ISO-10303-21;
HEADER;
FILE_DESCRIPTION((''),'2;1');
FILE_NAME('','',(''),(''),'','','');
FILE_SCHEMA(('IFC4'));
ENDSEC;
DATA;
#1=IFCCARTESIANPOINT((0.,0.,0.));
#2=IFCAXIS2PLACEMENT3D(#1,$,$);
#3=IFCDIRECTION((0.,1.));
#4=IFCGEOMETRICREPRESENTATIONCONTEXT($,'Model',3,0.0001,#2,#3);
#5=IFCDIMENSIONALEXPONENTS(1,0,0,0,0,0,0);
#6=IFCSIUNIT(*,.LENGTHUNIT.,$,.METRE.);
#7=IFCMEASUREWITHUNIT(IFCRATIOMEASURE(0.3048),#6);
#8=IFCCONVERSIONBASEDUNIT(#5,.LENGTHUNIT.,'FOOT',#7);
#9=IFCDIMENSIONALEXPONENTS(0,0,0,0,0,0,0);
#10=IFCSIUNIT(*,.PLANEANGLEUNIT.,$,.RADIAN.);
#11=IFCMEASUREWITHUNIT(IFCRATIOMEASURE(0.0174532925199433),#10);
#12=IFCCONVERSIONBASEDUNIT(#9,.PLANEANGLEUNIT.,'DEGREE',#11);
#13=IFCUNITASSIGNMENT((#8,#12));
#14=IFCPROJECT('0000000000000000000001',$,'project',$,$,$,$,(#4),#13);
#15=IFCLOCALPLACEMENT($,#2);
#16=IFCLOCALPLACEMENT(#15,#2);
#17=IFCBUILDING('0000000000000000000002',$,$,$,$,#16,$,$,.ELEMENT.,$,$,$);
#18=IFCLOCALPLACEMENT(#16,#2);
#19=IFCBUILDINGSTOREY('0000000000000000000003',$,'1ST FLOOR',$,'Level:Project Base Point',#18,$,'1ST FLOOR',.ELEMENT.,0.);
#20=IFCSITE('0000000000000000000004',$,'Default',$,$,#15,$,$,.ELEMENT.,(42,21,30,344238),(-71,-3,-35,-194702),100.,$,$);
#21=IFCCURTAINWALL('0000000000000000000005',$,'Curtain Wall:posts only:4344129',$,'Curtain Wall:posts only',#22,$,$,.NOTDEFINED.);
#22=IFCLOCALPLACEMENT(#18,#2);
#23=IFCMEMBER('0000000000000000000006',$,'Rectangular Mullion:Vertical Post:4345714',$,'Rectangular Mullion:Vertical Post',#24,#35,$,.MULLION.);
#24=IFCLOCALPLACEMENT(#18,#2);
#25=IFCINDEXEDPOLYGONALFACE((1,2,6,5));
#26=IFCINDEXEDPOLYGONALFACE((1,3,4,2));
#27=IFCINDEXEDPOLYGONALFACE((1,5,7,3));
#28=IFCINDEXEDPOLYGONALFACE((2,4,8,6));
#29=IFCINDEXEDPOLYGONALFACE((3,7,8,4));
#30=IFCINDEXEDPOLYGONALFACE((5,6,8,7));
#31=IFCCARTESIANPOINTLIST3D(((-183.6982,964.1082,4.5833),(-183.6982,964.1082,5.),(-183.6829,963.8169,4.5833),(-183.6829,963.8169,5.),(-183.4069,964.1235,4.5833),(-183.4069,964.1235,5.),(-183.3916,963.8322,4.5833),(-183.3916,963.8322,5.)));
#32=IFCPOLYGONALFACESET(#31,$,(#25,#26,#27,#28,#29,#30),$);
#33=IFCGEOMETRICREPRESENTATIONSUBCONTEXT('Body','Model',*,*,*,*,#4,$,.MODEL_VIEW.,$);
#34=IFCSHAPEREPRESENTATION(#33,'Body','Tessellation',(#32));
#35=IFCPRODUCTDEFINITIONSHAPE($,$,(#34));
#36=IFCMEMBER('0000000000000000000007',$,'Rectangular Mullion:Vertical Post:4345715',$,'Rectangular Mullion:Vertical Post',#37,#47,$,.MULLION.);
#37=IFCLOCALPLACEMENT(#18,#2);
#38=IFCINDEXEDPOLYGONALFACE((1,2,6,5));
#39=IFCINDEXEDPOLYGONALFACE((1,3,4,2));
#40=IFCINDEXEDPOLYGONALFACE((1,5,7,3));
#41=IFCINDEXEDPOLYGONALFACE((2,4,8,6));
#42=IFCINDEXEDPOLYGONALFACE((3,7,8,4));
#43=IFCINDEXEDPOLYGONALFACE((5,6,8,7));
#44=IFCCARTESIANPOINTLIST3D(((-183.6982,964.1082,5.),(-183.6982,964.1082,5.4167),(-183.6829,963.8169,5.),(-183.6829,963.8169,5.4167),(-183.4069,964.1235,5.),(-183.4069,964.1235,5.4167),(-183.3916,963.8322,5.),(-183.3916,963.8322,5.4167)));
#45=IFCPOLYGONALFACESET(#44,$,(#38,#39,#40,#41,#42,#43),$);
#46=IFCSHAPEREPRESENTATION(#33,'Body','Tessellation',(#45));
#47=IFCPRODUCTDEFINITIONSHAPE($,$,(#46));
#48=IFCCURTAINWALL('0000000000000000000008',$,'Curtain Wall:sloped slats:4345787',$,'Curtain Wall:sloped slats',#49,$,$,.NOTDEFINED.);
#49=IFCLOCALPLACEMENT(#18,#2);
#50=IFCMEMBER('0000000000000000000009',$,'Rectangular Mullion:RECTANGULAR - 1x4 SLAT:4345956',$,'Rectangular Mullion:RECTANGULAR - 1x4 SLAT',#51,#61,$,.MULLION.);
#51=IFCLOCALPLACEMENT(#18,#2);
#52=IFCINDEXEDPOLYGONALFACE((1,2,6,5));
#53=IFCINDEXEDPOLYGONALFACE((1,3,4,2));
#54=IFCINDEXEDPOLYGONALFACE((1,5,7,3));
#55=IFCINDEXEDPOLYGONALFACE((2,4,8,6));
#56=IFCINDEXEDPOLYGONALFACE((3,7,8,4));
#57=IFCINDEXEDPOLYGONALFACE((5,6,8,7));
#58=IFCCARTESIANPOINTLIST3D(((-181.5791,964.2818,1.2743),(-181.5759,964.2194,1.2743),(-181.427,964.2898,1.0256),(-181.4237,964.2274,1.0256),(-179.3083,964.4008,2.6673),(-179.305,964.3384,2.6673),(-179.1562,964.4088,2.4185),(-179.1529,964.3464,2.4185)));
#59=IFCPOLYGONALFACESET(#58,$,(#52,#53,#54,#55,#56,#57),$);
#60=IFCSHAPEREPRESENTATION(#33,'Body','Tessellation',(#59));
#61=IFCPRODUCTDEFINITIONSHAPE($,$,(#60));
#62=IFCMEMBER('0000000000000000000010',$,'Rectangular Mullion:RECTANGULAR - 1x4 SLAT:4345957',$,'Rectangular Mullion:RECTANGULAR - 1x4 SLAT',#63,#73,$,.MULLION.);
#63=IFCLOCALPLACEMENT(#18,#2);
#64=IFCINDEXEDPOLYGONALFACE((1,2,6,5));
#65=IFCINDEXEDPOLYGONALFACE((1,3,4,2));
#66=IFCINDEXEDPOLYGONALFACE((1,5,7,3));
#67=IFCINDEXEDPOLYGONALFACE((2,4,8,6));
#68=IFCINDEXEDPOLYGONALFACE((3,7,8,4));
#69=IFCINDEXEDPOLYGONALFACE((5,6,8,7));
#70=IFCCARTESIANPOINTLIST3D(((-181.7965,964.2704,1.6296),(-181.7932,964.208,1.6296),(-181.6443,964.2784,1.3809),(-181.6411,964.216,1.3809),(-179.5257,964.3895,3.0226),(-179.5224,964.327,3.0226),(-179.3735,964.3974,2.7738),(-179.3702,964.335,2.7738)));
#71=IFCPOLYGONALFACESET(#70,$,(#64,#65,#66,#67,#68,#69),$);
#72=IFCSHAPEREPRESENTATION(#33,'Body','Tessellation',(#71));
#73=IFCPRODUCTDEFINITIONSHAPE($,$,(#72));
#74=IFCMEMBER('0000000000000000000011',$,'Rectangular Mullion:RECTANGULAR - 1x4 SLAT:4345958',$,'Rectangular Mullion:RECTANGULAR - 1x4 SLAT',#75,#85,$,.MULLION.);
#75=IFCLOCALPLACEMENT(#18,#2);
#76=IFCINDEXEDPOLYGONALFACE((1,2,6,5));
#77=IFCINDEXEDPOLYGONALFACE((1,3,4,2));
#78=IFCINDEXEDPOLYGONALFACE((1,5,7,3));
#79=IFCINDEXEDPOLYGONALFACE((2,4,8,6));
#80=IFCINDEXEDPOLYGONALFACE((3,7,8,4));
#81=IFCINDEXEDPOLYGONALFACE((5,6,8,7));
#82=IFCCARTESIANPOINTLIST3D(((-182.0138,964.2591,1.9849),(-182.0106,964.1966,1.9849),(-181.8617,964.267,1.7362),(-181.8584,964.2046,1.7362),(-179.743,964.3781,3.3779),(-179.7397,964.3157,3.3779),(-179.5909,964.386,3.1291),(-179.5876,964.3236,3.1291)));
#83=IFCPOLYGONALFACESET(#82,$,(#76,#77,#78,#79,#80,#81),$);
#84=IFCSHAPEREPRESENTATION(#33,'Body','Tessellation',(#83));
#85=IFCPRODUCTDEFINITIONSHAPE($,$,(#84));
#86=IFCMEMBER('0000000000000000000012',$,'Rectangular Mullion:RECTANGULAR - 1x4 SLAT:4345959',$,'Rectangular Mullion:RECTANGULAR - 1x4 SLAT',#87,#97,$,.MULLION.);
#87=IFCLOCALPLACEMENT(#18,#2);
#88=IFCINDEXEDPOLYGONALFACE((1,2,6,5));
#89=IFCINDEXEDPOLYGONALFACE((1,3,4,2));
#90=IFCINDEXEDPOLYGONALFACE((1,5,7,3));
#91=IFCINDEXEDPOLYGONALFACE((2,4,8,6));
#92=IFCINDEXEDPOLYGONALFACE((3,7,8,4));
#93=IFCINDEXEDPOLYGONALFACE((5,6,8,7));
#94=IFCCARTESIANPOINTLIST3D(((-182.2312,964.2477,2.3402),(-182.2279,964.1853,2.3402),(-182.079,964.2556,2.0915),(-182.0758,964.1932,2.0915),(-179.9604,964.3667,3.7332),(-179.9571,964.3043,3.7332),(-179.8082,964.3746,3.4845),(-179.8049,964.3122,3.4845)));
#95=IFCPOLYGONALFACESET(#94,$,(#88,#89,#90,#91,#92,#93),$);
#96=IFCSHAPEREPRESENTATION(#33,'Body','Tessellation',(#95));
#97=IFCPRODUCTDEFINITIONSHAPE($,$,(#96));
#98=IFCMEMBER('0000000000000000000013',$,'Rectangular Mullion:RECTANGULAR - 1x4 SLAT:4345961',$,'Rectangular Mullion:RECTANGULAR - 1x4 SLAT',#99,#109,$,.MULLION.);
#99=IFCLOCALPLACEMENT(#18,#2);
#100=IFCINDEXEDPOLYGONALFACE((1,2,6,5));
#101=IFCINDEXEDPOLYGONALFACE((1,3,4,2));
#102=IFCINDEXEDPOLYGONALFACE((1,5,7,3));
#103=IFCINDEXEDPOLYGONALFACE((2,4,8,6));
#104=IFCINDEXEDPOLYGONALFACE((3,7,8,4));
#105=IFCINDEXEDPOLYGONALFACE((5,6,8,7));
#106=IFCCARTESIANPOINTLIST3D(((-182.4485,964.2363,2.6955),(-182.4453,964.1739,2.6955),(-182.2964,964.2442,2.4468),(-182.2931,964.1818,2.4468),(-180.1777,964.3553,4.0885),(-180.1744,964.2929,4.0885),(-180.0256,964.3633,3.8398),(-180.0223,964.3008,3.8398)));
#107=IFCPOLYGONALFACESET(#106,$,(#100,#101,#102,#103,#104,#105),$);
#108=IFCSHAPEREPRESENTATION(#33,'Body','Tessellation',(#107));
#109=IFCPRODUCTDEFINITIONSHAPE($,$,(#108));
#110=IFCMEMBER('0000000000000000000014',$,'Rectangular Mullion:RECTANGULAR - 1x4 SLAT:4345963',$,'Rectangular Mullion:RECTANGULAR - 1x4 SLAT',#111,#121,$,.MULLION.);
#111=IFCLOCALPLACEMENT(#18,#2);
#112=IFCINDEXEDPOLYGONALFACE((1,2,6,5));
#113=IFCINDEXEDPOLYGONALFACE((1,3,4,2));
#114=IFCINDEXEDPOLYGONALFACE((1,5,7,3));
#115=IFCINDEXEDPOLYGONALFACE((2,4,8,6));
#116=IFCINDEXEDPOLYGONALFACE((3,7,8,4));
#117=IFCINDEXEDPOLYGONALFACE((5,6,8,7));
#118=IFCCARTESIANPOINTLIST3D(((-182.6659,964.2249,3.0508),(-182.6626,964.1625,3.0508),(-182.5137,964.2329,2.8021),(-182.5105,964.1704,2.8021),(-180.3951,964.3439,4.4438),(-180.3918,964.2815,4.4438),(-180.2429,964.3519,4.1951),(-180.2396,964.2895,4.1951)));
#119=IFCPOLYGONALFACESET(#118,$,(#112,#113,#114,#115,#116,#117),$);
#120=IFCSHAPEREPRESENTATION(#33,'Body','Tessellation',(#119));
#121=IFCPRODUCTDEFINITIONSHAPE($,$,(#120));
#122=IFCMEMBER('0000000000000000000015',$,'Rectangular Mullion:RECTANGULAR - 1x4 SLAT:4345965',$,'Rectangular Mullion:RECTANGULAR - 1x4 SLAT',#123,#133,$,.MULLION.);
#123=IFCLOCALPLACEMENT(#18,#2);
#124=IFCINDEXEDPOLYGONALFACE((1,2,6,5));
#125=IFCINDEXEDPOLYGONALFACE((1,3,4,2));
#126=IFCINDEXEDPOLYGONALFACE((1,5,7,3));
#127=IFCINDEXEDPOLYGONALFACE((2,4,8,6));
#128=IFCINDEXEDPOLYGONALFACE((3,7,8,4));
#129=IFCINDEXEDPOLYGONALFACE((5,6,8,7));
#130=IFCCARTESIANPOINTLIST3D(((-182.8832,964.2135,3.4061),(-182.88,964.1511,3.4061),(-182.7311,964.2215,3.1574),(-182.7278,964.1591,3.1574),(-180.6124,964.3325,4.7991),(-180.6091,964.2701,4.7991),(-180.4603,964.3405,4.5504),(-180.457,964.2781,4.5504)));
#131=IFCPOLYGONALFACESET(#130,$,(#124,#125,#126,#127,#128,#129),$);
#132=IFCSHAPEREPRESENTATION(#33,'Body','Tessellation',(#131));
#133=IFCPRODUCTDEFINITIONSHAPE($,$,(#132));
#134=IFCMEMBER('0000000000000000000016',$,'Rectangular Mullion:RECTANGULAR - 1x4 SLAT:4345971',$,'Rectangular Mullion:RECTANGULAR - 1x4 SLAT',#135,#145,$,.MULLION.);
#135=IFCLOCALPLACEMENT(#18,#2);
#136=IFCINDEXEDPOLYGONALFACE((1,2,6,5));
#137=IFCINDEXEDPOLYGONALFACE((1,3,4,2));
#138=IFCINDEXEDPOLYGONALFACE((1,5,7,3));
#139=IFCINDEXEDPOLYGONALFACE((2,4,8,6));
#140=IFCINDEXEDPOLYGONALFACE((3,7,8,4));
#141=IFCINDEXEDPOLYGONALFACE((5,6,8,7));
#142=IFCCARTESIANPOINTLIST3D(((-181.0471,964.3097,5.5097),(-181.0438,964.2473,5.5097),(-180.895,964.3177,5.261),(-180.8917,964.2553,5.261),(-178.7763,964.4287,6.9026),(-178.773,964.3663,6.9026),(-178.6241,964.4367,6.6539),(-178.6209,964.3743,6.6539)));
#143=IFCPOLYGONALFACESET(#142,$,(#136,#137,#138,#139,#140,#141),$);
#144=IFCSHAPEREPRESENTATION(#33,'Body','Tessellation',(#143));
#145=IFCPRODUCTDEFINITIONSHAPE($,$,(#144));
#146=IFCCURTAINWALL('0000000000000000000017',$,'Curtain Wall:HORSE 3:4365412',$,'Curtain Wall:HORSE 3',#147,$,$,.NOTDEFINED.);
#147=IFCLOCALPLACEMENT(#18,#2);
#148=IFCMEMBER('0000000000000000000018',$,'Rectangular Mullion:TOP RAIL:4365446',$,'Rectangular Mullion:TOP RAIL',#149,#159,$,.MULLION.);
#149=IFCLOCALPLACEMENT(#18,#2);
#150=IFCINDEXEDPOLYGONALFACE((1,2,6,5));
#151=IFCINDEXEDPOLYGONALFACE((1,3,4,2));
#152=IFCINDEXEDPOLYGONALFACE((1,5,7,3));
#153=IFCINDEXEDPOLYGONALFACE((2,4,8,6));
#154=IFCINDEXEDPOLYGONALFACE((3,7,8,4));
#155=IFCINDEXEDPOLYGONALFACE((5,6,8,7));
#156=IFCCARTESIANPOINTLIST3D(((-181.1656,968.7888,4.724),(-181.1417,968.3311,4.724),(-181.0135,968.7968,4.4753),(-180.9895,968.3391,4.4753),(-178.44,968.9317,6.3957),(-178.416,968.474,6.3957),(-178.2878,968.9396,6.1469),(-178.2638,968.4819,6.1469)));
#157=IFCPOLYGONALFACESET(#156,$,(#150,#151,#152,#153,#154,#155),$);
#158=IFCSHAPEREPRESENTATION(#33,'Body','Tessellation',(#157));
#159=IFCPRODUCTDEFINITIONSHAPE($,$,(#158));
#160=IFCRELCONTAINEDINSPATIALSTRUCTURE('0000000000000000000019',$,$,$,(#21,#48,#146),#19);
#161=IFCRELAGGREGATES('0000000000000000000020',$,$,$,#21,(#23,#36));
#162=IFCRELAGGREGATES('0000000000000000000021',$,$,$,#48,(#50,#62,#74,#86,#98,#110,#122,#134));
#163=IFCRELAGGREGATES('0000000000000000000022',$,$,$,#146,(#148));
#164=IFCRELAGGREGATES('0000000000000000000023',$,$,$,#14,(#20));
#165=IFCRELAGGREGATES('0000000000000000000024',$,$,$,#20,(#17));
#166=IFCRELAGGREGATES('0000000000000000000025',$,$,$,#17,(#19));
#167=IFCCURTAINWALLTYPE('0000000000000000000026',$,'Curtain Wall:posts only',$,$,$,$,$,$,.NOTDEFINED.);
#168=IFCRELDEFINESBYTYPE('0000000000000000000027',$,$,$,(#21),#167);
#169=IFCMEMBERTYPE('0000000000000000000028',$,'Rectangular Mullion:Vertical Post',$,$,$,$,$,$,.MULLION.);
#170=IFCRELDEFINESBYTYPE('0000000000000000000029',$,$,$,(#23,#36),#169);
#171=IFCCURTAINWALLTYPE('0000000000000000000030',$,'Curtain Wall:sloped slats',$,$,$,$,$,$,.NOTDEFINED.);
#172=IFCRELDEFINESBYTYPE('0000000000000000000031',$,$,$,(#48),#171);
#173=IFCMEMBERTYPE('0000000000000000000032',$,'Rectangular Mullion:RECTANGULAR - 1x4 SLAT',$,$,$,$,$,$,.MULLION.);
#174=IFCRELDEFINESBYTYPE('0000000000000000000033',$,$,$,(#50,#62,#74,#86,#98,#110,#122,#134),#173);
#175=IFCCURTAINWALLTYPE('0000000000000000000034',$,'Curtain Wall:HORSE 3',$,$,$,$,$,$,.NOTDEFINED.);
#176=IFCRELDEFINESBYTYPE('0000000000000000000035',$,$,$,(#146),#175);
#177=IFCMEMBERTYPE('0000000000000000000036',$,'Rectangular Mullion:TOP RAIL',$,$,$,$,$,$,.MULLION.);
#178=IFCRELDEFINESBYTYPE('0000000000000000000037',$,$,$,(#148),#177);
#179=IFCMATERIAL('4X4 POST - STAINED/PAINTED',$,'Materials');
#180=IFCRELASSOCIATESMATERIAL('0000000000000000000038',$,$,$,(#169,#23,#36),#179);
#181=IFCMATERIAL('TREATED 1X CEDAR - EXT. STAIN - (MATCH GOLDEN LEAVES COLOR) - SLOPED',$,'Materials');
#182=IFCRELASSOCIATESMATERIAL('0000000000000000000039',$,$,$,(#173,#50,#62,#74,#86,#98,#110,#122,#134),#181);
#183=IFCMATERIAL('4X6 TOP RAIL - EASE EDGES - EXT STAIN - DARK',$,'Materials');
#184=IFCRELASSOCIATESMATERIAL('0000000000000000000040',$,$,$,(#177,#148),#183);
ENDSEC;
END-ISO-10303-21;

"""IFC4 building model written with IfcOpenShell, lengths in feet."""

from ifc_helpers import new_model, entity, si_unit, converted_unit, direction, frame, frame_2d, origin, origin_2d_with_axis, place, context, subcontext, project, spatial, rectangle, extrude, source, transform, mapped, material, material_profile, profile_set, profile_usage, type_object, type_shapes, element, aggregate, save


model = new_model("IFC4")

# Units and contexts
model_context = context("Model", 3, precision=0.0001, world=origin(), true_north=direction((0.0, 1.0)))
body_context = subcontext(model_context, "Body", "Model", "MODEL_VIEW")
ifc_project = project(units=[converted_unit("LENGTHUNIT", "FOOT", entity("IfcRatioMeasure", 0.3048), si_unit("LENGTHUNIT", "METRE"), dimensions=[1, 0, 0, 0, 0, 0, 0]), converted_unit("PLANEANGLEUNIT", "DEGREE", entity("IfcRatioMeasure", 0.0174532925199433), si_unit("PLANEANGLEUNIT", "RADIAN"), dimensions=[0, 0, 0, 0, 0, 0, 0])], contexts=[model_context])

# Site, building, storey
site_placement = place(None, origin())
site = spatial("IfcSite", under=ifc_project, at=site_placement, Name="Default", CompositionType="ELEMENT", RefLatitude=(42, 21, 30, 344238), RefLongitude=(-71, -3, -35, -194702), RefElevation=100.0)
building_placement = place(site_placement, origin())
building = spatial("IfcBuilding", under=site, at=building_placement, CompositionType="ELEMENT")
storey_placement = place(building_placement, origin())
storey = spatial("IfcBuildingStorey", under=building, at=storey_placement, Name="1ST FLOOR", ObjectType="Level:Project Base Point", LongName="1ST FLOOR", CompositionType="ELEMENT", Elevation=0.0)

# Curtain walls, members
curtain_wall_type_1 = type_object("IfcCurtainWallType", Name="Curtain Wall:posts only", PredefinedType="NOTDEFINED")
curtain_wall_1_placement = place(storey_placement, origin())
curtain_wall_1 = element("IfcCurtainWall", 1, at=curtain_wall_1_placement, inside=storey, type_object=curtain_wall_type_1, Name="Curtain Wall:posts only:4344129", ObjectType="Curtain Wall:posts only", PredefinedType="NOTDEFINED")
ifc_material_1 = material(Name="4X4 POST - STAINED/PAINTED", Category="Materials")
ifc_material_profile_1 = material_profile(ifc_material_1, rectangle(XDim=0.2917, YDim=0.2917, at=origin_2d_with_axis()), Name="Vertical Post")
ifc_profile_set_1 = profile_set([ifc_material_profile_1], Name="Vertical Post")
member_type_1 = type_object("IfcMemberType", Name="Rectangular Mullion:Vertical Post", PredefinedType="MULLION", material=ifc_profile_set_1)
shared_shape_1 = source(origin(), body_context, "Body", "SweptSolid", [
    extrude(rectangle(XDim=0.2917, YDim=0.2917, at=origin_2d_with_axis()), frame((0.0, -0.2083, -0.4167), z_axis=(0.0, 0.0, 1.0), x_axis=(0.0, -1.0, 0.0)), (0.0, 0.0, 1.0), 0.4167),
])
type_shapes(member_type_1, [shared_shape_1])
ifc_profile_usage_1 = profile_usage(ifc_profile_set_1)
member_1_placement = place(storey_placement, frame((-183.5558, 964.1782, 4.5833), z_axis=(0.0, 0.0, -1.0), x_axis=(-0.99863, -0.052336, 0.0)))
member_1 = element("IfcMember", 2, at=member_1_placement, type_object=member_type_1, material=ifc_profile_usage_1, Name="Rectangular Mullion:Vertical Post:4345714", ObjectType="Rectangular Mullion:Vertical Post", PredefinedType="MULLION", context=body_context, shape_type="MappedRepresentation", body=[
    mapped(shared_shape_1, transform((0.0, 0.0, 0.0), scale=1.0)),
])
ifc_profile_usage_2 = profile_usage(ifc_profile_set_1)
member_2_placement = place(storey_placement, frame((-183.5558, 964.1782, 5.0), z_axis=(0.0, 0.0, -1.0), x_axis=(-0.99863, -0.052336, 0.0)))
member_2 = element("IfcMember", 3, at=member_2_placement, type_object=member_type_1, material=ifc_profile_usage_2, Name="Rectangular Mullion:Vertical Post:4345715", ObjectType="Rectangular Mullion:Vertical Post", PredefinedType="MULLION", context=body_context, shape_type="MappedRepresentation", body=[
    mapped(shared_shape_1, transform((0.0, 0.0, 0.0), scale=1.0)),
])
aggregate(curtain_wall_1, [member_1, member_2])
curtain_wall_type_2 = type_object("IfcCurtainWallType", Name="Curtain Wall:sloped slats", PredefinedType="NOTDEFINED")
curtain_wall_2_placement = place(storey_placement, origin())
curtain_wall_2 = element("IfcCurtainWall", 4, at=curtain_wall_2_placement, inside=storey, type_object=curtain_wall_type_2, Name="Curtain Wall:sloped slats:4345787", ObjectType="Curtain Wall:sloped slats", PredefinedType="NOTDEFINED")
ifc_material_2 = material(Name="TREATED 1X CEDAR - EXT. STAIN - (MATCH GOLDEN LEAVES COLOR) - SLOPED", Category="Materials")
ifc_material_profile_2 = material_profile(ifc_material_2, rectangle(XDim=0.0625, YDim=0.2917, at=frame_2d((0.0, 0.0), x_axis=(1.0, 0.0))), Name="RECTANGULAR - 1x4 SLAT")
ifc_profile_set_2 = profile_set([ifc_material_profile_2], Name="RECTANGULAR - 1x4 SLAT")
ifc_profile_usage_3 = profile_usage(ifc_profile_set_2)
member_type_2 = type_object("IfcMemberType", Name="Rectangular Mullion:RECTANGULAR - 1x4 SLAT", PredefinedType="MULLION", material=ifc_profile_set_2)
shared_shape_2 = source(origin(), body_context, "Body", "SweptSolid", [
    extrude(rectangle(XDim=0.0625, YDim=0.2917, at=frame_2d((0.0, 0.0), x_axis=(1.0, 0.0))), frame((0.0, 0.0, -2.6667), z_axis=(0.0, 0.0, 1.0), x_axis=(0.0, -1.0, 0.0)), (0.0, 0.0, 1.0), 2.6667),
])
type_shapes(member_type_2, [shared_shape_2])
member_3_placement = place(storey_placement, frame((-181.5014, 964.2546, 1.1499), z_axis=(-0.851559, -0.044628, -0.522356), x_axis=(-0.52164, -0.027338, 0.852727)))
member_3 = element("IfcMember", 5, at=member_3_placement, type_object=member_type_2, material=ifc_profile_usage_3, Name="Rectangular Mullion:RECTANGULAR - 1x4 SLAT:4345956", ObjectType="Rectangular Mullion:RECTANGULAR - 1x4 SLAT", PredefinedType="MULLION", context=body_context, shape_type="MappedRepresentation", body=[
    mapped(shared_shape_2, transform((0.0, 0.0, 0.0), scale=1.0)),
])
ifc_profile_usage_4 = profile_usage(ifc_profile_set_2)
member_4_placement = place(storey_placement, frame((-181.7188, 964.2432, 1.5053), z_axis=(-0.851559, -0.044628, -0.522356), x_axis=(-0.52164, -0.027338, 0.852727)))
member_4 = element("IfcMember", 6, at=member_4_placement, type_object=member_type_2, material=ifc_profile_usage_4, Name="Rectangular Mullion:RECTANGULAR - 1x4 SLAT:4345957", ObjectType="Rectangular Mullion:RECTANGULAR - 1x4 SLAT", PredefinedType="MULLION", context=body_context, shape_type="MappedRepresentation", body=[
    mapped(shared_shape_2, transform((0.0, 0.0, 0.0), scale=1.0)),
])
ifc_profile_usage_5 = profile_usage(ifc_profile_set_2)
member_5_placement = place(storey_placement, frame((-181.9361, 964.2318, 1.8606), z_axis=(-0.851559, -0.044628, -0.522356), x_axis=(-0.52164, -0.027338, 0.852727)))
member_5 = element("IfcMember", 7, at=member_5_placement, type_object=member_type_2, material=ifc_profile_usage_5, Name="Rectangular Mullion:RECTANGULAR - 1x4 SLAT:4345958", ObjectType="Rectangular Mullion:RECTANGULAR - 1x4 SLAT", PredefinedType="MULLION", context=body_context, shape_type="MappedRepresentation", body=[
    mapped(shared_shape_2, transform((0.0, 0.0, 0.0), scale=1.0)),
])
ifc_profile_usage_6 = profile_usage(ifc_profile_set_2)
member_6_placement = place(storey_placement, frame((-182.1535, 964.2204, 2.2159), z_axis=(-0.851559, -0.044628, -0.522356), x_axis=(-0.52164, -0.027338, 0.852727)))
member_6 = element("IfcMember", 8, at=member_6_placement, type_object=member_type_2, material=ifc_profile_usage_6, Name="Rectangular Mullion:RECTANGULAR - 1x4 SLAT:4345959", ObjectType="Rectangular Mullion:RECTANGULAR - 1x4 SLAT", PredefinedType="MULLION", context=body_context, shape_type="MappedRepresentation", body=[
    mapped(shared_shape_2, transform((0.0, 0.0, 0.0), scale=1.0)),
])
ifc_profile_usage_7 = profile_usage(ifc_profile_set_2)
member_7_placement = place(storey_placement, frame((-182.3708, 964.2091, 2.5712), z_axis=(-0.851559, -0.044628, -0.522356), x_axis=(-0.52164, -0.027338, 0.852727)))
member_7 = element("IfcMember", 9, at=member_7_placement, type_object=member_type_2, material=ifc_profile_usage_7, Name="Rectangular Mullion:RECTANGULAR - 1x4 SLAT:4345961", ObjectType="Rectangular Mullion:RECTANGULAR - 1x4 SLAT", PredefinedType="MULLION", context=body_context, shape_type="MappedRepresentation", body=[
    mapped(shared_shape_2, transform((0.0, 0.0, 0.0), scale=1.0)),
])
ifc_profile_usage_8 = profile_usage(ifc_profile_set_2)
member_8_placement = place(storey_placement, frame((-182.5882, 964.1977, 2.9265), z_axis=(-0.851559, -0.044628, -0.522356), x_axis=(-0.52164, -0.027338, 0.852727)))
member_8 = element("IfcMember", 10, at=member_8_placement, type_object=member_type_2, material=ifc_profile_usage_8, Name="Rectangular Mullion:RECTANGULAR - 1x4 SLAT:4345963", ObjectType="Rectangular Mullion:RECTANGULAR - 1x4 SLAT", PredefinedType="MULLION", context=body_context, shape_type="MappedRepresentation", body=[
    mapped(shared_shape_2, transform((0.0, 0.0, 0.0), scale=1.0)),
])
ifc_profile_usage_9 = profile_usage(ifc_profile_set_2)
member_9_placement = place(storey_placement, frame((-182.8055, 964.1863, 3.2818), z_axis=(-0.851559, -0.044628, -0.522356), x_axis=(-0.52164, -0.027338, 0.852727)))
member_9 = element("IfcMember", 11, at=member_9_placement, type_object=member_type_2, material=ifc_profile_usage_9, Name="Rectangular Mullion:RECTANGULAR - 1x4 SLAT:4345965", ObjectType="Rectangular Mullion:RECTANGULAR - 1x4 SLAT", PredefinedType="MULLION", context=body_context, shape_type="MappedRepresentation", body=[
    mapped(shared_shape_2, transform((0.0, 0.0, 0.0), scale=1.0)),
])
ifc_profile_usage_10 = profile_usage(ifc_profile_set_2)
member_10_placement = place(storey_placement, frame((-180.9694, 964.2825, 5.3853), z_axis=(-0.851559, -0.044628, -0.522356), x_axis=(-0.52164, -0.027338, 0.852727)))
member_10 = element("IfcMember", 12, at=member_10_placement, type_object=member_type_2, material=ifc_profile_usage_10, Name="Rectangular Mullion:RECTANGULAR - 1x4 SLAT:4345971", ObjectType="Rectangular Mullion:RECTANGULAR - 1x4 SLAT", PredefinedType="MULLION", context=body_context, shape_type="MappedRepresentation", body=[
    mapped(shared_shape_2, transform((0.0, 0.0, 0.0), scale=1.0)),
])
aggregate(curtain_wall_2, [member_3, member_4, member_5, member_6, member_7, member_8, member_9, member_10])

# Curtain wall, member
curtain_wall_type_3 = type_object("IfcCurtainWallType", Name="Curtain Wall:HORSE 3", PredefinedType="NOTDEFINED")
curtain_wall_3_placement = place(storey_placement, origin())
curtain_wall_3 = element("IfcCurtainWall", 13, at=curtain_wall_3_placement, inside=storey, type_object=curtain_wall_type_3, Name="Curtain Wall:HORSE 3:4365412", ObjectType="Curtain Wall:HORSE 3", PredefinedType="NOTDEFINED")
ifc_material_3 = material(Name="4X6 TOP RAIL - EASE EDGES - EXT STAIN - DARK", Category="Materials")
ifc_material_profile_3 = material_profile(ifc_material_3, rectangle(XDim=0.4583, YDim=0.2917, at=origin_2d_with_axis()), Name="TOP RAIL")
ifc_profile_set_3 = profile_set([ifc_material_profile_3], Name="TOP RAIL")
ifc_profile_usage_11 = profile_usage(ifc_profile_set_3)
member_type_3 = type_object("IfcMemberType", Name="Rectangular Mullion:TOP RAIL", PredefinedType="MULLION", material=ifc_profile_set_3)
shared_shape_3 = source(origin(), body_context, "Body", "SweptSolid", [
    extrude(rectangle(XDim=0.4583, YDim=0.2917, at=frame_2d((0.0, 0.0), x_axis=(1.0, 0.0))), frame((-0.1458, 0.0625, -3.2006), z_axis=(0.0, 0.0, 1.0), x_axis=(0.0, -1.0, 0.0)), (0.0, 0.0, 1.0), 3.2006),
])
type_shapes(member_type_3, [shared_shape_3])
member_11_placement = place(storey_placement, frame((-181.1504, 968.4976, 4.724), z_axis=(-0.851606, -0.044631, -0.522279), x_axis=(-0.521563, -0.027334, 0.852775)))
member_11 = element("IfcMember", 14, at=member_11_placement, type_object=member_type_3, material=ifc_profile_usage_11, Name="Rectangular Mullion:TOP RAIL:4365446", ObjectType="Rectangular Mullion:TOP RAIL", PredefinedType="MULLION", context=body_context, shape_type="MappedRepresentation", body=[
    mapped(shared_shape_3, transform((0.0, 0.0, 0.0), scale=1.0)),
])
aggregate(curtain_wall_3, [member_11])

save(model, "model.ifc")
